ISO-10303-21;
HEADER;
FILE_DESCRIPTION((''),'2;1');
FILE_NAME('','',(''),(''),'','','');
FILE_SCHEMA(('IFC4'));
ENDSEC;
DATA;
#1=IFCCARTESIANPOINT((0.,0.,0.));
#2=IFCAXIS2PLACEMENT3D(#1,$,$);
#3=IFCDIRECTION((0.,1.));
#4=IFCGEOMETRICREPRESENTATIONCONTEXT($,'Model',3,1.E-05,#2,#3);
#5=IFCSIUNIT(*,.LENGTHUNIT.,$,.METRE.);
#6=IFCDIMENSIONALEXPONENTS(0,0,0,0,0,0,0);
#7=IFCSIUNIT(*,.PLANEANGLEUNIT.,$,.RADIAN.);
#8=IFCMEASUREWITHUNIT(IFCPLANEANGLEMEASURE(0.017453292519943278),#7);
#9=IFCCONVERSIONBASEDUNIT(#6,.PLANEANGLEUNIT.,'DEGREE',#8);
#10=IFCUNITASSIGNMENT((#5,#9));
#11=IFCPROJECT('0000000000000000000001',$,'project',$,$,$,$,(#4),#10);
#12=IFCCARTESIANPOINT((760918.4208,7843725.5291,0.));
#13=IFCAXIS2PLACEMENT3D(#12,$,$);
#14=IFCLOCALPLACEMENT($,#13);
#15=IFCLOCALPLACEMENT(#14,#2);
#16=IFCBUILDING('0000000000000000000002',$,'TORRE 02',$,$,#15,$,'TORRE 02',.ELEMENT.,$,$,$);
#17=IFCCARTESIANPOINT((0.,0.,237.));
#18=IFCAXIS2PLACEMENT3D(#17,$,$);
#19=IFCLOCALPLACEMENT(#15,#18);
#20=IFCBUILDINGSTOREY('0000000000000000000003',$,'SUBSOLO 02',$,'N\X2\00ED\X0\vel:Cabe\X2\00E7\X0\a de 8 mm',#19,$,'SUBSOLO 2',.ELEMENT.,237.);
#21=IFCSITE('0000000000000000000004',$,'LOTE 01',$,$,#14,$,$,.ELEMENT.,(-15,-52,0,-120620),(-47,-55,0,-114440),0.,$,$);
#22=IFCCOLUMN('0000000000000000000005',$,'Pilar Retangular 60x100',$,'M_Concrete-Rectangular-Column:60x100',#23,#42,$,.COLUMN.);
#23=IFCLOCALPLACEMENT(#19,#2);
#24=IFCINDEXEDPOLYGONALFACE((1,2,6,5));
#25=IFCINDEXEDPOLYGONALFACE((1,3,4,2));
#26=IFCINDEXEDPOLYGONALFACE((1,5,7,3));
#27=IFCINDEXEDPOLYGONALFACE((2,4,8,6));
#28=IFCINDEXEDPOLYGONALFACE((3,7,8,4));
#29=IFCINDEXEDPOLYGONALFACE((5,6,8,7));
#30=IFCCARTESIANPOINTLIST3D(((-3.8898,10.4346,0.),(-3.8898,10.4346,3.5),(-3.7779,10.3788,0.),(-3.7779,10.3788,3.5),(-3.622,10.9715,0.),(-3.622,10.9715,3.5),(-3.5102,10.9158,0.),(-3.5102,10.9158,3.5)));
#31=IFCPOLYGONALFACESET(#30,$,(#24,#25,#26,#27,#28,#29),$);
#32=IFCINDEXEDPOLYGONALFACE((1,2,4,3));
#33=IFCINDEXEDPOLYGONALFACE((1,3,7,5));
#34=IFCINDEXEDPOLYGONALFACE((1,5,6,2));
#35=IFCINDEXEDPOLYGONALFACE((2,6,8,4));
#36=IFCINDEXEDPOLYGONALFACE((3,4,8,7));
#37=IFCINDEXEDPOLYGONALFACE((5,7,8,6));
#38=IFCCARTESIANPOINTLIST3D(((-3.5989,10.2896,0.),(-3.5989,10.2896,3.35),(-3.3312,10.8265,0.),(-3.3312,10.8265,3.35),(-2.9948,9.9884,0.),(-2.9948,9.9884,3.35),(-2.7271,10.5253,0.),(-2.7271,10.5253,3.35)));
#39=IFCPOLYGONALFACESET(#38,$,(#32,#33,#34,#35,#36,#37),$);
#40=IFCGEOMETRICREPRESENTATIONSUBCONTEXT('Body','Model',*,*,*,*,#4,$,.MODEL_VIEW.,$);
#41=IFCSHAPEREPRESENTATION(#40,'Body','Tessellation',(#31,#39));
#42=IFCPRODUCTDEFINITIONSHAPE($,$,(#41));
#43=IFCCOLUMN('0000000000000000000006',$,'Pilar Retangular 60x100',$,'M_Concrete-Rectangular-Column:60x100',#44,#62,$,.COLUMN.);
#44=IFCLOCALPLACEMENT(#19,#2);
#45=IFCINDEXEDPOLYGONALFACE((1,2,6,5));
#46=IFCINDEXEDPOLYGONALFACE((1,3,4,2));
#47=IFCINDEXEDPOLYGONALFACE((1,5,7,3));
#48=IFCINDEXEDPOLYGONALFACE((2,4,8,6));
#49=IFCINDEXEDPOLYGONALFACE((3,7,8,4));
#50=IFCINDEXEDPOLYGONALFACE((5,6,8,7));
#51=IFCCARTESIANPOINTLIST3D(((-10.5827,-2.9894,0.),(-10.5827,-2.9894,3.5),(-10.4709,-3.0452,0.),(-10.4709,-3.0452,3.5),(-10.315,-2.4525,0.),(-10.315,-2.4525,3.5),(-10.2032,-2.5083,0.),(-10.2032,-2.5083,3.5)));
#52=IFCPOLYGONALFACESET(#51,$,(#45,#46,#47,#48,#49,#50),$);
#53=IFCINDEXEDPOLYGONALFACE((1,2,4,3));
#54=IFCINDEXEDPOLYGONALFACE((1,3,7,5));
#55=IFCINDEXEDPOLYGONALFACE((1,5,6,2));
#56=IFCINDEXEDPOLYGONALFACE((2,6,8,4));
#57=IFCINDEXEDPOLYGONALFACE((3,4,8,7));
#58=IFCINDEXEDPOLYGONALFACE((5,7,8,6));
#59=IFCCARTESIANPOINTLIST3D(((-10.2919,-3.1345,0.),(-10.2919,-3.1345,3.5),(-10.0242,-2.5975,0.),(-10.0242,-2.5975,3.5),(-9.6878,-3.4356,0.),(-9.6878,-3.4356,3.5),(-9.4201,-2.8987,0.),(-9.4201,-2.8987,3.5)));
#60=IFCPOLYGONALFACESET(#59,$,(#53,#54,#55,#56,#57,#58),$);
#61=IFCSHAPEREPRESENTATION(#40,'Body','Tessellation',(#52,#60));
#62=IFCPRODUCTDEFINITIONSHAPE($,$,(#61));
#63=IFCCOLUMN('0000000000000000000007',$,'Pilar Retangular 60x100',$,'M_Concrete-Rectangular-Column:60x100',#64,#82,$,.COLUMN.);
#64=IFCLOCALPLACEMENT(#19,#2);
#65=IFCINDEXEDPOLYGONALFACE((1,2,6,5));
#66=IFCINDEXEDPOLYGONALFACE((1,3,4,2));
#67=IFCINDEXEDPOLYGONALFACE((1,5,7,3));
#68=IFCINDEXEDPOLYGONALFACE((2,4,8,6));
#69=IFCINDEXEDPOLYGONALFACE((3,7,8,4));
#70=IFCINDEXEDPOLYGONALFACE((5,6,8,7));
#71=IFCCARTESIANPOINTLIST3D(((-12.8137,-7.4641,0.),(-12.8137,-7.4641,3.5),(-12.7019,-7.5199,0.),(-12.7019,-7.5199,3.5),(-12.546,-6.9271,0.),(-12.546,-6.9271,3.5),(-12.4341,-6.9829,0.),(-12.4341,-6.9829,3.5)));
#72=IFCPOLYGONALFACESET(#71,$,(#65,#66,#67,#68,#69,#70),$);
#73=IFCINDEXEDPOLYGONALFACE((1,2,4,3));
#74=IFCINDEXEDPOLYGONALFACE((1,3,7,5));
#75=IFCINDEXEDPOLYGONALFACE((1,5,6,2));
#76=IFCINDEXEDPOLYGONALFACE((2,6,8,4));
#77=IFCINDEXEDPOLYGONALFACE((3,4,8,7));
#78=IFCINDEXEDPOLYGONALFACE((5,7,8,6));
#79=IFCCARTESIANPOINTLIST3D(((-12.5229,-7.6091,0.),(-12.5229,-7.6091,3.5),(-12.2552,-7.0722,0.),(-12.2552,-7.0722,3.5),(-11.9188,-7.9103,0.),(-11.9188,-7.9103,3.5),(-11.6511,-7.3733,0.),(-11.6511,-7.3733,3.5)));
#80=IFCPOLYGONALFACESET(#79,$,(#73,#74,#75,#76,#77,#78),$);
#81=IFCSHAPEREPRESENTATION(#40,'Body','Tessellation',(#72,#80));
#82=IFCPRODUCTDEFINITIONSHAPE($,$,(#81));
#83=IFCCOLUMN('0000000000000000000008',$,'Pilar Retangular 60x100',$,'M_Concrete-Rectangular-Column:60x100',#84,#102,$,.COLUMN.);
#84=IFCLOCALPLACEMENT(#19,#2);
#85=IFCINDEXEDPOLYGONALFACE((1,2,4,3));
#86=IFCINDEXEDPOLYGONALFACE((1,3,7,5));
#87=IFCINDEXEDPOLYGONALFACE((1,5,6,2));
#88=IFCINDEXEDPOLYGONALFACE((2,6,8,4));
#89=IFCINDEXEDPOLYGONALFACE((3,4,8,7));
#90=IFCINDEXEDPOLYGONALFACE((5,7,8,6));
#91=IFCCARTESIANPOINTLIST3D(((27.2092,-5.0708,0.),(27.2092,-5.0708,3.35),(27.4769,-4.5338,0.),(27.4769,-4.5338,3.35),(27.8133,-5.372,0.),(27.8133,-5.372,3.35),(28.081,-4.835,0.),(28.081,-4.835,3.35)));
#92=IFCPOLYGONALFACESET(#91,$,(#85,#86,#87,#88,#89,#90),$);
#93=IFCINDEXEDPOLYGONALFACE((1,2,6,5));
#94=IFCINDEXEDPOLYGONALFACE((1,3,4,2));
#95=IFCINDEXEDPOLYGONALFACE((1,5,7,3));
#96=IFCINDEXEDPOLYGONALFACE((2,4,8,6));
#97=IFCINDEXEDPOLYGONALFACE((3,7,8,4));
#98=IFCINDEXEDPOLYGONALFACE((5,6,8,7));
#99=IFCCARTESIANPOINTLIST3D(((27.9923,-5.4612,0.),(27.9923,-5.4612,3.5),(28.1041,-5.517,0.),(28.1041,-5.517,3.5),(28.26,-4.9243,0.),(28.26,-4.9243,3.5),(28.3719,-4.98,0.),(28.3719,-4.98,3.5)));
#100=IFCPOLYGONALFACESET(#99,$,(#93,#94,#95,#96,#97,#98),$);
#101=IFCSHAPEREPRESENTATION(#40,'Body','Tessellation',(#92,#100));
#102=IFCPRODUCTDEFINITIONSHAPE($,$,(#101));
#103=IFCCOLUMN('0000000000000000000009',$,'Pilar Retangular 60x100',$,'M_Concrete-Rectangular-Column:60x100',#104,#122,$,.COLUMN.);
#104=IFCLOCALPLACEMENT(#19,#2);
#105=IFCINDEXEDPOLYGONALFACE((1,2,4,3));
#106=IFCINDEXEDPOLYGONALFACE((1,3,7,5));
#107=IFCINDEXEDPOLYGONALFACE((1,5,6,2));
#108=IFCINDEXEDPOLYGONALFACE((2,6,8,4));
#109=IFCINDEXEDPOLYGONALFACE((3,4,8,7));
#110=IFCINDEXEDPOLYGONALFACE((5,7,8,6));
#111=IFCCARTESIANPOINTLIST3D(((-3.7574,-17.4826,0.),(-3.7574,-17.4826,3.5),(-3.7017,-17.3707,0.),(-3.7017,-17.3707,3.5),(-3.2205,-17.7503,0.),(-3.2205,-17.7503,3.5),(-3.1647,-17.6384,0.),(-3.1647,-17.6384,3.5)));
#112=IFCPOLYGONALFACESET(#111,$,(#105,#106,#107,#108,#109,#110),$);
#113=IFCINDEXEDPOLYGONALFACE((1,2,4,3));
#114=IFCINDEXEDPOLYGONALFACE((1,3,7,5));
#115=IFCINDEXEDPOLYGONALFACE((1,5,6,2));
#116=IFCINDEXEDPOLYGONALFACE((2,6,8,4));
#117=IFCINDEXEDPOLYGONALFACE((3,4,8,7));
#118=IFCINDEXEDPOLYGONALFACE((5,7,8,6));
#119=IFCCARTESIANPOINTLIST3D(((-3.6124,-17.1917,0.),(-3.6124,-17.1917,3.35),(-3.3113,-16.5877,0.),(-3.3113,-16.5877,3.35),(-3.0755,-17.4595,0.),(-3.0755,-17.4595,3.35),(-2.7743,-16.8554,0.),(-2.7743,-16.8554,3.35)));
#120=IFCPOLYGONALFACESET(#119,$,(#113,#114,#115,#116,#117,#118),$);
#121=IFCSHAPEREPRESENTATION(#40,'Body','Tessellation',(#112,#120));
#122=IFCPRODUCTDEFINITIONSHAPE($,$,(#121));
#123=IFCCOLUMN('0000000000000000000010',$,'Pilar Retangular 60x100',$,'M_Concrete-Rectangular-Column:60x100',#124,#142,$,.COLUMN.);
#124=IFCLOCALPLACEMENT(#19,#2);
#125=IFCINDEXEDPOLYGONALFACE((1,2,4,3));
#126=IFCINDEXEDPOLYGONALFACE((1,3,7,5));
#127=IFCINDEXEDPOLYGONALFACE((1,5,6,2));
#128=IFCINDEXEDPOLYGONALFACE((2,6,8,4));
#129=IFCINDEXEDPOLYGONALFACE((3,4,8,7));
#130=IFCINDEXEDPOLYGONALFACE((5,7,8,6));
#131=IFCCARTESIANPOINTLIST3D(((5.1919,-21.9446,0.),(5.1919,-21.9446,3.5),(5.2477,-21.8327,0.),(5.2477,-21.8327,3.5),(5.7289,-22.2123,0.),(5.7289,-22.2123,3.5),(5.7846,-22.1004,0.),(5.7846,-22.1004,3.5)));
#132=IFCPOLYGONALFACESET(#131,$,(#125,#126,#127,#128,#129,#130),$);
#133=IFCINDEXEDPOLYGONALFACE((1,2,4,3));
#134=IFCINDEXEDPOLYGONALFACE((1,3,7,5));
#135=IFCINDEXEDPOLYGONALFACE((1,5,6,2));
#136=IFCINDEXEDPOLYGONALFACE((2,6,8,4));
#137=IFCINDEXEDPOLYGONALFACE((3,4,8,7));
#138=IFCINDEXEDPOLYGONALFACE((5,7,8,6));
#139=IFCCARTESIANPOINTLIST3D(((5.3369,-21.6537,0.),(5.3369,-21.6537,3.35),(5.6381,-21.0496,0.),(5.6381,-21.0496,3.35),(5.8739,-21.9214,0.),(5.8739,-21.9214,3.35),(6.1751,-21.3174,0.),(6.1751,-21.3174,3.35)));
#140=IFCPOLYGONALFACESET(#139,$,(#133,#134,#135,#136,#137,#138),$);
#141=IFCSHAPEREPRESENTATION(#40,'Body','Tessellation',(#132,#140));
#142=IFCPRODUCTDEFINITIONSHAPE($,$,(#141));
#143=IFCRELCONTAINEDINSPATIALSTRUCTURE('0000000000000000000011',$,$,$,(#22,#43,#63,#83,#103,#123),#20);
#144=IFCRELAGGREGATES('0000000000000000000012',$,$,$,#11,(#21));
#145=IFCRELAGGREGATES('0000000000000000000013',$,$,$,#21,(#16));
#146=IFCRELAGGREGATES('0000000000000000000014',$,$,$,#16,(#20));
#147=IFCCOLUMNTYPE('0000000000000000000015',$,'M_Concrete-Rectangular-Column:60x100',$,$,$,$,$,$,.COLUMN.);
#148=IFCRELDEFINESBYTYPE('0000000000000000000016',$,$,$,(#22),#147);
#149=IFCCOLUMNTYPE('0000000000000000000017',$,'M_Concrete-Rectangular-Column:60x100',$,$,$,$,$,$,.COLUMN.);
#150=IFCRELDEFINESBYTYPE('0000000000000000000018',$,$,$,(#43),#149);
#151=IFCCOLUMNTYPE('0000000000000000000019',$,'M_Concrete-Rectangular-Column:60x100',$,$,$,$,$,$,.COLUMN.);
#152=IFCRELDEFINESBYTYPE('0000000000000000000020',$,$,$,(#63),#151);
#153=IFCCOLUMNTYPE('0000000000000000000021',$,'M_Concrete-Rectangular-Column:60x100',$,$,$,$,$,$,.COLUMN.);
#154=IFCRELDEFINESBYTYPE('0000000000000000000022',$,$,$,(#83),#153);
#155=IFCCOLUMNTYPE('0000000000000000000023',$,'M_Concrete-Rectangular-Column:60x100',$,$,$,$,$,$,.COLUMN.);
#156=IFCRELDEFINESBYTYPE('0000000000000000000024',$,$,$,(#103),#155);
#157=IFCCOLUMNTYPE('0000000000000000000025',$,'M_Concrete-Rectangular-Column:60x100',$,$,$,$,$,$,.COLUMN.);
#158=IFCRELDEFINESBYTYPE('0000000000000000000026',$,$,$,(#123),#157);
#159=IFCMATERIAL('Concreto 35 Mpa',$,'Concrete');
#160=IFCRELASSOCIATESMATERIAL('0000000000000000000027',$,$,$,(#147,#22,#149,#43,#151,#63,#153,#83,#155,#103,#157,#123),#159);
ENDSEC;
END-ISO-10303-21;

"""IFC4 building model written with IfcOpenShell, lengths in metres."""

from ifc_helpers import new_model, entity, si_unit, converted_unit, direction, frame, origin, place, context, subcontext, project, spatial, indexed_curve, outline, extrude, source, transform, mapped, material, type_object, type_shapes, element, save


model = new_model("IFC4")

# Units and contexts
model_context = context("Model", 3, precision=1e-05, world=origin(), true_north=direction((0.0, 1.0)))
body_context = subcontext(model_context, "Body", "Model", "MODEL_VIEW")
ifc_project = project(units=[si_unit("LENGTHUNIT", "METRE"), converted_unit("PLANEANGLEUNIT", "DEGREE", entity("IfcPlaneAngleMeasure", 0.017453292519943278), si_unit("PLANEANGLEUNIT", "RADIAN"), dimensions=[0, 0, 0, 0, 0, 0, 0])], contexts=[model_context])

# Site, building, storey
site_placement = place(None, frame((760918.4208, 7843725.5291, 0.0)))
site = spatial("IfcSite", under=ifc_project, at=site_placement, Name="LOTE 01", CompositionType="ELEMENT", RefLatitude=(-15, -52, 0, -120620), RefLongitude=(-47, -55, 0, -114440), RefElevation=0.0)
building_placement = place(site_placement, origin())
building = spatial("IfcBuilding", under=site, at=building_placement, Name="TORRE 02", LongName="TORRE 02", CompositionType="ELEMENT")
storey_placement = place(building_placement, frame((0.0, 0.0, 237.0)))
storey = spatial("IfcBuildingStorey", under=building, at=storey_placement, Name="SUBSOLO 02", ObjectType="Nível:Cabeça de 8 mm", LongName="SUBSOLO 2", CompositionType="ELEMENT", Elevation=237.0)

# Shared definitions
placement = place(building_placement, frame((0.0, 0.0, 237.0)))

# Columns
ifc_material_1 = material(Name="Concreto 35 Mpa", Category="Concrete")
column_type_1 = type_object("IfcColumnType", Name="M_Concrete-Rectangular-Column:60x100", PredefinedType="COLUMN", material=ifc_material_1)
shared_shape_1 = source(origin(), body_context, "Body", "SweptSolid", [
    extrude(outline(indexed_curve([(-0.0625, -0.3), (0.0625, -0.3), (0.0625, 0.3), (-0.0625, 0.3), (-0.0625, -0.3)], self_intersect=False)), frame((-3.7, 10.6752, 237.0), z_axis=(0.0, 0.0, 1.0), x_axis=(0.894934, -0.446198, 0.0)), (0.0, 0.0, 1.0), 3.5),
    extrude(outline(indexed_curve([(-0.3375, -0.3), (0.3375, -0.3), (0.3375, 0.3), (-0.3375, 0.3), (-0.3375, -0.3)], self_intersect=False)), frame((-3.163, 10.4075, 237.0), z_axis=(0.0, 0.0, 1.0), x_axis=(-0.894934, 0.446198, 0.0)), (0.0, 0.0, 1.0), 3.35),
])
type_shapes(column_type_1, [shared_shape_1])
column_1_placement = place(placement, frame((0.0, 0.0, -237.0)))
element("IfcColumn", 1, at=column_1_placement, inside=storey, type_object=column_type_1, material=ifc_material_1, Name="Pilar Retangular 60x100", ObjectType="M_Concrete-Rectangular-Column:60x100", PredefinedType="COLUMN", context=body_context, shape_type="MappedRepresentation", body=[
    mapped(shared_shape_1, transform((0.0, 0.0, 0.0), scale=1.0)),
])
column_type_2 = type_object("IfcColumnType", Name="M_Concrete-Rectangular-Column:60x100", PredefinedType="COLUMN", material=ifc_material_1)
shared_shape_2 = source(origin(), body_context, "Body", "SweptSolid", [
    extrude(outline(indexed_curve([(-0.0625, -0.3), (0.0625, -0.3), (0.0625, 0.3), (-0.0625, 0.3), (-0.0625, -0.3)], self_intersect=False)), frame((-10.3929, -2.7488, 237.0), z_axis=(0.0, 0.0, 1.0), x_axis=(0.894934, -0.446198, 0.0)), (0.0, 0.0, 1.0), 3.5),
    extrude(outline(indexed_curve([(-0.3375, -0.3), (0.3375, -0.3), (0.3375, 0.3), (-0.3375, 0.3), (-0.3375, -0.3)], self_intersect=False)), frame((-9.856, -3.0166, 237.0), z_axis=(0.0, 0.0, 1.0), x_axis=(-0.894934, 0.446198, 0.0)), (0.0, 0.0, 1.0), 3.5),
])
type_shapes(column_type_2, [shared_shape_2])
column_2_placement = place(placement, frame((0.0, 0.0, -237.0)))
element("IfcColumn", 2, at=column_2_placement, inside=storey, type_object=column_type_2, material=ifc_material_1, Name="Pilar Retangular 60x100", ObjectType="M_Concrete-Rectangular-Column:60x100", PredefinedType="COLUMN", context=body_context, shape_type="MappedRepresentation", body=[
    mapped(shared_shape_2, transform((0.0, 0.0, 0.0), scale=1.0)),
])
column_type_3 = type_object("IfcColumnType", Name="M_Concrete-Rectangular-Column:60x100", PredefinedType="COLUMN", material=ifc_material_1)
shared_shape_3 = source(origin(), body_context, "Body", "SweptSolid", [
    extrude(outline(indexed_curve([(-0.0625, -0.3), (0.0625, -0.3), (0.0625, 0.3), (-0.0625, 0.3), (-0.0625, -0.3)], self_intersect=False)), frame((-12.6239, -7.2235, 237.0), z_axis=(0.0, 0.0, 1.0), x_axis=(0.894934, -0.446198, 0.0)), (0.0, 0.0, 1.0), 3.5),
    extrude(outline(indexed_curve([(-0.3375, -0.3), (0.3375, -0.3), (0.3375, 0.3), (-0.3375, 0.3), (-0.3375, -0.3)], self_intersect=False)), frame((-12.087, -7.4912, 237.0), z_axis=(0.0, 0.0, 1.0), x_axis=(-0.894934, 0.446198, 0.0)), (0.0, 0.0, 1.0), 3.5),
])
type_shapes(column_type_3, [shared_shape_3])
column_3_placement = place(placement, frame((0.0, 0.0, -237.0)))
element("IfcColumn", 3, at=column_3_placement, inside=storey, type_object=column_type_3, material=ifc_material_1, Name="Pilar Retangular 60x100", ObjectType="M_Concrete-Rectangular-Column:60x100", PredefinedType="COLUMN", context=body_context, shape_type="MappedRepresentation", body=[
    mapped(shared_shape_3, transform((0.0, 0.0, 0.0), scale=1.0)),
])
column_type_4 = type_object("IfcColumnType", Name="M_Concrete-Rectangular-Column:60x100", PredefinedType="COLUMN", material=ifc_material_1)
shared_shape_4 = source(origin(), body_context, "Body", "SweptSolid", [
    extrude(outline(indexed_curve([(-0.3375, -0.3), (0.3375, -0.3), (0.3375, 0.3), (-0.3375, 0.3), (-0.3375, -0.3)], self_intersect=False)), frame((27.6451, -4.9529, 237.0), z_axis=(0.0, 0.0, 1.0), x_axis=(0.894934, -0.446198, 0.0)), (0.0, 0.0, 1.0), 3.35),
    extrude(outline(indexed_curve([(-0.0625, -0.3), (0.0625, -0.3), (0.0625, 0.3), (-0.0625, 0.3), (-0.0625, -0.3)], self_intersect=False)), frame((28.1821, -5.2206, 237.0), z_axis=(0.0, 0.0, 1.0), x_axis=(-0.894934, 0.446198, 0.0)), (0.0, 0.0, 1.0), 3.5),
])
type_shapes(column_type_4, [shared_shape_4])
column_4_placement = place(placement, frame((0.0, 0.0, -237.0)))
element("IfcColumn", 4, at=column_4_placement, inside=storey, type_object=column_type_4, material=ifc_material_1, Name="Pilar Retangular 60x100", ObjectType="M_Concrete-Rectangular-Column:60x100", PredefinedType="COLUMN", context=body_context, shape_type="MappedRepresentation", body=[
    mapped(shared_shape_4, transform((0.0, 0.0, 0.0), scale=1.0)),
])
column_type_5 = type_object("IfcColumnType", Name="M_Concrete-Rectangular-Column:60x100", PredefinedType="COLUMN", material=ifc_material_1)
shared_shape_5 = source(origin(), body_context, "Body", "SweptSolid", [
    extrude(outline(indexed_curve([(-0.0625, -0.3), (0.0625, -0.3), (0.0625, 0.3), (-0.0625, 0.3), (-0.0625, -0.3)], self_intersect=False)), frame((-3.4611, -17.5605, 237.0), z_axis=(0.0, 0.0, 1.0), x_axis=(0.446198, 0.894934, 0.0)), (0.0, 0.0, 1.0), 3.5),
    extrude(outline(indexed_curve([(-1.675, -0.3375), (1.675, -0.3375), (1.675, 0.3375), (-1.675, 0.3375), (-1.675, -0.3375)], self_intersect=False)), frame((-3.4618, -16.8897, 238.675), z_axis=(0.894934, -0.446198, 0.0), x_axis=(0.0, 0.0, 1.0)), (0.0, 0.0, 1.0), 0.6),
])
type_shapes(column_type_5, [shared_shape_5])
column_5_placement = place(placement, frame((0.0, 0.0, -237.0)))
element("IfcColumn", 5, at=column_5_placement, inside=storey, type_object=column_type_5, material=ifc_material_1, Name="Pilar Retangular 60x100", ObjectType="M_Concrete-Rectangular-Column:60x100", PredefinedType="COLUMN", context=body_context, shape_type="MappedRepresentation", body=[
    mapped(shared_shape_5, transform((0.0, 0.0, 0.0), scale=1.0)),
])
column_type_6 = type_object("IfcColumnType", Name="M_Concrete-Rectangular-Column:60x100", PredefinedType="COLUMN", material=ifc_material_1)
shared_shape_6 = source(origin(), body_context, "Body", "SweptSolid", [
    extrude(outline(indexed_curve([(-0.0625, -0.3), (0.0625, -0.3), (0.0625, 0.3), (-0.0625, 0.3), (-0.0625, -0.3)], self_intersect=False)), frame((5.4883, -22.0225, 237.0), z_axis=(0.0, 0.0, 1.0), x_axis=(0.446198, 0.894934, 0.0)), (0.0, 0.0, 1.0), 3.5),
    extrude(outline(indexed_curve([(-1.675, -0.3375), (1.675, -0.3375), (1.675, 0.3375), (-1.675, 0.3375), (-1.675, -0.3375)], self_intersect=False)), frame((5.4875, -21.3517, 238.675), z_axis=(0.894934, -0.446198, 0.0), x_axis=(0.0, 0.0, 1.0)), (0.0, 0.0, 1.0), 0.6),
])
type_shapes(column_type_6, [shared_shape_6])
column_6_placement = place(placement, frame((0.0, 0.0, -237.0)))
element("IfcColumn", 6, at=column_6_placement, inside=storey, type_object=column_type_6, material=ifc_material_1, Name="Pilar Retangular 60x100", ObjectType="M_Concrete-Rectangular-Column:60x100", PredefinedType="COLUMN", context=body_context, shape_type="MappedRepresentation", body=[
    mapped(shared_shape_6, transform((0.0, 0.0, 0.0), scale=1.0)),
])

save(model, "model.ifc")
